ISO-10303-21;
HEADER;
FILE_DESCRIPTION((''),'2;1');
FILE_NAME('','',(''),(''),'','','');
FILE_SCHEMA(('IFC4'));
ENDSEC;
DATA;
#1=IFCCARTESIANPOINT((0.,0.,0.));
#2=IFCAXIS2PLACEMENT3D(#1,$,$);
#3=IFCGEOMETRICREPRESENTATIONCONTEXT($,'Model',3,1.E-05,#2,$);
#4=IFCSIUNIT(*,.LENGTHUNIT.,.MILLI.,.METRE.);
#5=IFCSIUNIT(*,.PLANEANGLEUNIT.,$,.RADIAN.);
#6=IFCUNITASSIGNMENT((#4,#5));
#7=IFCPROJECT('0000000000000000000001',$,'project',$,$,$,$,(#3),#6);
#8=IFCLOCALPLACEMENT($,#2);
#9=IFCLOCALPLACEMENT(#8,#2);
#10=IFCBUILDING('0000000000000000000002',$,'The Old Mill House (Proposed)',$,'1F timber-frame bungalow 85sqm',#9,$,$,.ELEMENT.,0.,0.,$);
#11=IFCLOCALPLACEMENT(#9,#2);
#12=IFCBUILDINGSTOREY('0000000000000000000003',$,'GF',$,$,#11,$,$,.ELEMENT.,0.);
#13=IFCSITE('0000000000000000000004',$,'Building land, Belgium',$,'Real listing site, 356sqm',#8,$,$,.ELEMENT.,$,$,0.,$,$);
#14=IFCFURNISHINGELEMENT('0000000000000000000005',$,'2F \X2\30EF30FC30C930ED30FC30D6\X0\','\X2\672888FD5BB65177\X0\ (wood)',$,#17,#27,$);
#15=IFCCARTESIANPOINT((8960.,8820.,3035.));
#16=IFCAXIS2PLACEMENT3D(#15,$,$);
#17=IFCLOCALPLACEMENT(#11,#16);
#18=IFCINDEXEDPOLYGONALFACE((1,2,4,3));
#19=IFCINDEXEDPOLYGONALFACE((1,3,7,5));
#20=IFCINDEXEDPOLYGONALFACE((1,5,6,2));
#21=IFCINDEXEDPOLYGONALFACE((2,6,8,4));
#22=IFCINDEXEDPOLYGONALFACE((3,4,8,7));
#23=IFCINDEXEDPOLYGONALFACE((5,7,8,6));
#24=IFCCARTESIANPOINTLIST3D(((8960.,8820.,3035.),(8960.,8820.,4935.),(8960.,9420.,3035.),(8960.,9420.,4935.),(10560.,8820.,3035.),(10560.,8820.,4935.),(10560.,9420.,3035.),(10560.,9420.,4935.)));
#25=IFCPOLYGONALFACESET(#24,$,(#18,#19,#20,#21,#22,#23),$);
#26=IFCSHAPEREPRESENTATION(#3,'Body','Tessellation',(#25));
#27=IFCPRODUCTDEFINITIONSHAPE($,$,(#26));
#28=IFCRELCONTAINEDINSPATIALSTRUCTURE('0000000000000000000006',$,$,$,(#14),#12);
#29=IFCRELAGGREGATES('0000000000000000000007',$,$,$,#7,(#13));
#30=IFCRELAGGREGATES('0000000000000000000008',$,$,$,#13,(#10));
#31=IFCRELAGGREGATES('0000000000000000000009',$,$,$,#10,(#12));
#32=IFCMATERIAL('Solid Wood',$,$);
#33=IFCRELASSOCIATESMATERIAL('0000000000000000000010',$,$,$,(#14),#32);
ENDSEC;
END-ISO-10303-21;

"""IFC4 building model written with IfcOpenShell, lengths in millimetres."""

from ifc_helpers import new_model, si_unit, frame, frame_2d, origin, place, context, project, spatial, rectangle, extrude, material, element, save


model = new_model("IFC4")

# Units and contexts
model_context = context("Model", 3, precision=1e-05, world=origin())
ifc_project = project(units=[si_unit("LENGTHUNIT", "METRE", prefix="MILLI"), si_unit("PLANEANGLEUNIT", "RADIAN")], contexts=[model_context])

# Site, building, storey
site_placement = place(None, origin())
site = spatial("IfcSite", under=ifc_project, at=site_placement, Name="Building land, Belgium", ObjectType="Real listing site, 356sqm", CompositionType="ELEMENT", RefElevation=0.0)
building_placement = place(site_placement, origin())
building = spatial("IfcBuilding", under=site, at=building_placement, Name="The Old Mill House (Proposed)", ObjectType="1F timber-frame bungalow 85sqm", CompositionType="ELEMENT", ElevationOfRefHeight=0.0, ElevationOfTerrain=0.0)
storey_placement = place(building_placement, origin())
storey = spatial("IfcBuildingStorey", under=building, at=storey_placement, Name="GF", CompositionType="ELEMENT", Elevation=0.0)

# Shared definitions
ifc_material_1 = material(Name="Solid Wood")

# Furnishing element
furnishing_1_placement = place(storey_placement, frame((8960.0, 8820.0, 3035.0)))
element("IfcFurnishingElement", 1, at=furnishing_1_placement, inside=storey, material=ifc_material_1, Name="2F ワードローブ", Description="木製家具 (wood)", context=model_context, shape_type="SweptSolid", body=[
    extrude(rectangle(XDim=1600.0, YDim=600.0, at=frame_2d((800.0, 300.0))), frame((8960.0, 8820.0, 3035.0)), (0.0, 0.0, 1.0), 1900.0),
])

save(model, "model.ifc")
